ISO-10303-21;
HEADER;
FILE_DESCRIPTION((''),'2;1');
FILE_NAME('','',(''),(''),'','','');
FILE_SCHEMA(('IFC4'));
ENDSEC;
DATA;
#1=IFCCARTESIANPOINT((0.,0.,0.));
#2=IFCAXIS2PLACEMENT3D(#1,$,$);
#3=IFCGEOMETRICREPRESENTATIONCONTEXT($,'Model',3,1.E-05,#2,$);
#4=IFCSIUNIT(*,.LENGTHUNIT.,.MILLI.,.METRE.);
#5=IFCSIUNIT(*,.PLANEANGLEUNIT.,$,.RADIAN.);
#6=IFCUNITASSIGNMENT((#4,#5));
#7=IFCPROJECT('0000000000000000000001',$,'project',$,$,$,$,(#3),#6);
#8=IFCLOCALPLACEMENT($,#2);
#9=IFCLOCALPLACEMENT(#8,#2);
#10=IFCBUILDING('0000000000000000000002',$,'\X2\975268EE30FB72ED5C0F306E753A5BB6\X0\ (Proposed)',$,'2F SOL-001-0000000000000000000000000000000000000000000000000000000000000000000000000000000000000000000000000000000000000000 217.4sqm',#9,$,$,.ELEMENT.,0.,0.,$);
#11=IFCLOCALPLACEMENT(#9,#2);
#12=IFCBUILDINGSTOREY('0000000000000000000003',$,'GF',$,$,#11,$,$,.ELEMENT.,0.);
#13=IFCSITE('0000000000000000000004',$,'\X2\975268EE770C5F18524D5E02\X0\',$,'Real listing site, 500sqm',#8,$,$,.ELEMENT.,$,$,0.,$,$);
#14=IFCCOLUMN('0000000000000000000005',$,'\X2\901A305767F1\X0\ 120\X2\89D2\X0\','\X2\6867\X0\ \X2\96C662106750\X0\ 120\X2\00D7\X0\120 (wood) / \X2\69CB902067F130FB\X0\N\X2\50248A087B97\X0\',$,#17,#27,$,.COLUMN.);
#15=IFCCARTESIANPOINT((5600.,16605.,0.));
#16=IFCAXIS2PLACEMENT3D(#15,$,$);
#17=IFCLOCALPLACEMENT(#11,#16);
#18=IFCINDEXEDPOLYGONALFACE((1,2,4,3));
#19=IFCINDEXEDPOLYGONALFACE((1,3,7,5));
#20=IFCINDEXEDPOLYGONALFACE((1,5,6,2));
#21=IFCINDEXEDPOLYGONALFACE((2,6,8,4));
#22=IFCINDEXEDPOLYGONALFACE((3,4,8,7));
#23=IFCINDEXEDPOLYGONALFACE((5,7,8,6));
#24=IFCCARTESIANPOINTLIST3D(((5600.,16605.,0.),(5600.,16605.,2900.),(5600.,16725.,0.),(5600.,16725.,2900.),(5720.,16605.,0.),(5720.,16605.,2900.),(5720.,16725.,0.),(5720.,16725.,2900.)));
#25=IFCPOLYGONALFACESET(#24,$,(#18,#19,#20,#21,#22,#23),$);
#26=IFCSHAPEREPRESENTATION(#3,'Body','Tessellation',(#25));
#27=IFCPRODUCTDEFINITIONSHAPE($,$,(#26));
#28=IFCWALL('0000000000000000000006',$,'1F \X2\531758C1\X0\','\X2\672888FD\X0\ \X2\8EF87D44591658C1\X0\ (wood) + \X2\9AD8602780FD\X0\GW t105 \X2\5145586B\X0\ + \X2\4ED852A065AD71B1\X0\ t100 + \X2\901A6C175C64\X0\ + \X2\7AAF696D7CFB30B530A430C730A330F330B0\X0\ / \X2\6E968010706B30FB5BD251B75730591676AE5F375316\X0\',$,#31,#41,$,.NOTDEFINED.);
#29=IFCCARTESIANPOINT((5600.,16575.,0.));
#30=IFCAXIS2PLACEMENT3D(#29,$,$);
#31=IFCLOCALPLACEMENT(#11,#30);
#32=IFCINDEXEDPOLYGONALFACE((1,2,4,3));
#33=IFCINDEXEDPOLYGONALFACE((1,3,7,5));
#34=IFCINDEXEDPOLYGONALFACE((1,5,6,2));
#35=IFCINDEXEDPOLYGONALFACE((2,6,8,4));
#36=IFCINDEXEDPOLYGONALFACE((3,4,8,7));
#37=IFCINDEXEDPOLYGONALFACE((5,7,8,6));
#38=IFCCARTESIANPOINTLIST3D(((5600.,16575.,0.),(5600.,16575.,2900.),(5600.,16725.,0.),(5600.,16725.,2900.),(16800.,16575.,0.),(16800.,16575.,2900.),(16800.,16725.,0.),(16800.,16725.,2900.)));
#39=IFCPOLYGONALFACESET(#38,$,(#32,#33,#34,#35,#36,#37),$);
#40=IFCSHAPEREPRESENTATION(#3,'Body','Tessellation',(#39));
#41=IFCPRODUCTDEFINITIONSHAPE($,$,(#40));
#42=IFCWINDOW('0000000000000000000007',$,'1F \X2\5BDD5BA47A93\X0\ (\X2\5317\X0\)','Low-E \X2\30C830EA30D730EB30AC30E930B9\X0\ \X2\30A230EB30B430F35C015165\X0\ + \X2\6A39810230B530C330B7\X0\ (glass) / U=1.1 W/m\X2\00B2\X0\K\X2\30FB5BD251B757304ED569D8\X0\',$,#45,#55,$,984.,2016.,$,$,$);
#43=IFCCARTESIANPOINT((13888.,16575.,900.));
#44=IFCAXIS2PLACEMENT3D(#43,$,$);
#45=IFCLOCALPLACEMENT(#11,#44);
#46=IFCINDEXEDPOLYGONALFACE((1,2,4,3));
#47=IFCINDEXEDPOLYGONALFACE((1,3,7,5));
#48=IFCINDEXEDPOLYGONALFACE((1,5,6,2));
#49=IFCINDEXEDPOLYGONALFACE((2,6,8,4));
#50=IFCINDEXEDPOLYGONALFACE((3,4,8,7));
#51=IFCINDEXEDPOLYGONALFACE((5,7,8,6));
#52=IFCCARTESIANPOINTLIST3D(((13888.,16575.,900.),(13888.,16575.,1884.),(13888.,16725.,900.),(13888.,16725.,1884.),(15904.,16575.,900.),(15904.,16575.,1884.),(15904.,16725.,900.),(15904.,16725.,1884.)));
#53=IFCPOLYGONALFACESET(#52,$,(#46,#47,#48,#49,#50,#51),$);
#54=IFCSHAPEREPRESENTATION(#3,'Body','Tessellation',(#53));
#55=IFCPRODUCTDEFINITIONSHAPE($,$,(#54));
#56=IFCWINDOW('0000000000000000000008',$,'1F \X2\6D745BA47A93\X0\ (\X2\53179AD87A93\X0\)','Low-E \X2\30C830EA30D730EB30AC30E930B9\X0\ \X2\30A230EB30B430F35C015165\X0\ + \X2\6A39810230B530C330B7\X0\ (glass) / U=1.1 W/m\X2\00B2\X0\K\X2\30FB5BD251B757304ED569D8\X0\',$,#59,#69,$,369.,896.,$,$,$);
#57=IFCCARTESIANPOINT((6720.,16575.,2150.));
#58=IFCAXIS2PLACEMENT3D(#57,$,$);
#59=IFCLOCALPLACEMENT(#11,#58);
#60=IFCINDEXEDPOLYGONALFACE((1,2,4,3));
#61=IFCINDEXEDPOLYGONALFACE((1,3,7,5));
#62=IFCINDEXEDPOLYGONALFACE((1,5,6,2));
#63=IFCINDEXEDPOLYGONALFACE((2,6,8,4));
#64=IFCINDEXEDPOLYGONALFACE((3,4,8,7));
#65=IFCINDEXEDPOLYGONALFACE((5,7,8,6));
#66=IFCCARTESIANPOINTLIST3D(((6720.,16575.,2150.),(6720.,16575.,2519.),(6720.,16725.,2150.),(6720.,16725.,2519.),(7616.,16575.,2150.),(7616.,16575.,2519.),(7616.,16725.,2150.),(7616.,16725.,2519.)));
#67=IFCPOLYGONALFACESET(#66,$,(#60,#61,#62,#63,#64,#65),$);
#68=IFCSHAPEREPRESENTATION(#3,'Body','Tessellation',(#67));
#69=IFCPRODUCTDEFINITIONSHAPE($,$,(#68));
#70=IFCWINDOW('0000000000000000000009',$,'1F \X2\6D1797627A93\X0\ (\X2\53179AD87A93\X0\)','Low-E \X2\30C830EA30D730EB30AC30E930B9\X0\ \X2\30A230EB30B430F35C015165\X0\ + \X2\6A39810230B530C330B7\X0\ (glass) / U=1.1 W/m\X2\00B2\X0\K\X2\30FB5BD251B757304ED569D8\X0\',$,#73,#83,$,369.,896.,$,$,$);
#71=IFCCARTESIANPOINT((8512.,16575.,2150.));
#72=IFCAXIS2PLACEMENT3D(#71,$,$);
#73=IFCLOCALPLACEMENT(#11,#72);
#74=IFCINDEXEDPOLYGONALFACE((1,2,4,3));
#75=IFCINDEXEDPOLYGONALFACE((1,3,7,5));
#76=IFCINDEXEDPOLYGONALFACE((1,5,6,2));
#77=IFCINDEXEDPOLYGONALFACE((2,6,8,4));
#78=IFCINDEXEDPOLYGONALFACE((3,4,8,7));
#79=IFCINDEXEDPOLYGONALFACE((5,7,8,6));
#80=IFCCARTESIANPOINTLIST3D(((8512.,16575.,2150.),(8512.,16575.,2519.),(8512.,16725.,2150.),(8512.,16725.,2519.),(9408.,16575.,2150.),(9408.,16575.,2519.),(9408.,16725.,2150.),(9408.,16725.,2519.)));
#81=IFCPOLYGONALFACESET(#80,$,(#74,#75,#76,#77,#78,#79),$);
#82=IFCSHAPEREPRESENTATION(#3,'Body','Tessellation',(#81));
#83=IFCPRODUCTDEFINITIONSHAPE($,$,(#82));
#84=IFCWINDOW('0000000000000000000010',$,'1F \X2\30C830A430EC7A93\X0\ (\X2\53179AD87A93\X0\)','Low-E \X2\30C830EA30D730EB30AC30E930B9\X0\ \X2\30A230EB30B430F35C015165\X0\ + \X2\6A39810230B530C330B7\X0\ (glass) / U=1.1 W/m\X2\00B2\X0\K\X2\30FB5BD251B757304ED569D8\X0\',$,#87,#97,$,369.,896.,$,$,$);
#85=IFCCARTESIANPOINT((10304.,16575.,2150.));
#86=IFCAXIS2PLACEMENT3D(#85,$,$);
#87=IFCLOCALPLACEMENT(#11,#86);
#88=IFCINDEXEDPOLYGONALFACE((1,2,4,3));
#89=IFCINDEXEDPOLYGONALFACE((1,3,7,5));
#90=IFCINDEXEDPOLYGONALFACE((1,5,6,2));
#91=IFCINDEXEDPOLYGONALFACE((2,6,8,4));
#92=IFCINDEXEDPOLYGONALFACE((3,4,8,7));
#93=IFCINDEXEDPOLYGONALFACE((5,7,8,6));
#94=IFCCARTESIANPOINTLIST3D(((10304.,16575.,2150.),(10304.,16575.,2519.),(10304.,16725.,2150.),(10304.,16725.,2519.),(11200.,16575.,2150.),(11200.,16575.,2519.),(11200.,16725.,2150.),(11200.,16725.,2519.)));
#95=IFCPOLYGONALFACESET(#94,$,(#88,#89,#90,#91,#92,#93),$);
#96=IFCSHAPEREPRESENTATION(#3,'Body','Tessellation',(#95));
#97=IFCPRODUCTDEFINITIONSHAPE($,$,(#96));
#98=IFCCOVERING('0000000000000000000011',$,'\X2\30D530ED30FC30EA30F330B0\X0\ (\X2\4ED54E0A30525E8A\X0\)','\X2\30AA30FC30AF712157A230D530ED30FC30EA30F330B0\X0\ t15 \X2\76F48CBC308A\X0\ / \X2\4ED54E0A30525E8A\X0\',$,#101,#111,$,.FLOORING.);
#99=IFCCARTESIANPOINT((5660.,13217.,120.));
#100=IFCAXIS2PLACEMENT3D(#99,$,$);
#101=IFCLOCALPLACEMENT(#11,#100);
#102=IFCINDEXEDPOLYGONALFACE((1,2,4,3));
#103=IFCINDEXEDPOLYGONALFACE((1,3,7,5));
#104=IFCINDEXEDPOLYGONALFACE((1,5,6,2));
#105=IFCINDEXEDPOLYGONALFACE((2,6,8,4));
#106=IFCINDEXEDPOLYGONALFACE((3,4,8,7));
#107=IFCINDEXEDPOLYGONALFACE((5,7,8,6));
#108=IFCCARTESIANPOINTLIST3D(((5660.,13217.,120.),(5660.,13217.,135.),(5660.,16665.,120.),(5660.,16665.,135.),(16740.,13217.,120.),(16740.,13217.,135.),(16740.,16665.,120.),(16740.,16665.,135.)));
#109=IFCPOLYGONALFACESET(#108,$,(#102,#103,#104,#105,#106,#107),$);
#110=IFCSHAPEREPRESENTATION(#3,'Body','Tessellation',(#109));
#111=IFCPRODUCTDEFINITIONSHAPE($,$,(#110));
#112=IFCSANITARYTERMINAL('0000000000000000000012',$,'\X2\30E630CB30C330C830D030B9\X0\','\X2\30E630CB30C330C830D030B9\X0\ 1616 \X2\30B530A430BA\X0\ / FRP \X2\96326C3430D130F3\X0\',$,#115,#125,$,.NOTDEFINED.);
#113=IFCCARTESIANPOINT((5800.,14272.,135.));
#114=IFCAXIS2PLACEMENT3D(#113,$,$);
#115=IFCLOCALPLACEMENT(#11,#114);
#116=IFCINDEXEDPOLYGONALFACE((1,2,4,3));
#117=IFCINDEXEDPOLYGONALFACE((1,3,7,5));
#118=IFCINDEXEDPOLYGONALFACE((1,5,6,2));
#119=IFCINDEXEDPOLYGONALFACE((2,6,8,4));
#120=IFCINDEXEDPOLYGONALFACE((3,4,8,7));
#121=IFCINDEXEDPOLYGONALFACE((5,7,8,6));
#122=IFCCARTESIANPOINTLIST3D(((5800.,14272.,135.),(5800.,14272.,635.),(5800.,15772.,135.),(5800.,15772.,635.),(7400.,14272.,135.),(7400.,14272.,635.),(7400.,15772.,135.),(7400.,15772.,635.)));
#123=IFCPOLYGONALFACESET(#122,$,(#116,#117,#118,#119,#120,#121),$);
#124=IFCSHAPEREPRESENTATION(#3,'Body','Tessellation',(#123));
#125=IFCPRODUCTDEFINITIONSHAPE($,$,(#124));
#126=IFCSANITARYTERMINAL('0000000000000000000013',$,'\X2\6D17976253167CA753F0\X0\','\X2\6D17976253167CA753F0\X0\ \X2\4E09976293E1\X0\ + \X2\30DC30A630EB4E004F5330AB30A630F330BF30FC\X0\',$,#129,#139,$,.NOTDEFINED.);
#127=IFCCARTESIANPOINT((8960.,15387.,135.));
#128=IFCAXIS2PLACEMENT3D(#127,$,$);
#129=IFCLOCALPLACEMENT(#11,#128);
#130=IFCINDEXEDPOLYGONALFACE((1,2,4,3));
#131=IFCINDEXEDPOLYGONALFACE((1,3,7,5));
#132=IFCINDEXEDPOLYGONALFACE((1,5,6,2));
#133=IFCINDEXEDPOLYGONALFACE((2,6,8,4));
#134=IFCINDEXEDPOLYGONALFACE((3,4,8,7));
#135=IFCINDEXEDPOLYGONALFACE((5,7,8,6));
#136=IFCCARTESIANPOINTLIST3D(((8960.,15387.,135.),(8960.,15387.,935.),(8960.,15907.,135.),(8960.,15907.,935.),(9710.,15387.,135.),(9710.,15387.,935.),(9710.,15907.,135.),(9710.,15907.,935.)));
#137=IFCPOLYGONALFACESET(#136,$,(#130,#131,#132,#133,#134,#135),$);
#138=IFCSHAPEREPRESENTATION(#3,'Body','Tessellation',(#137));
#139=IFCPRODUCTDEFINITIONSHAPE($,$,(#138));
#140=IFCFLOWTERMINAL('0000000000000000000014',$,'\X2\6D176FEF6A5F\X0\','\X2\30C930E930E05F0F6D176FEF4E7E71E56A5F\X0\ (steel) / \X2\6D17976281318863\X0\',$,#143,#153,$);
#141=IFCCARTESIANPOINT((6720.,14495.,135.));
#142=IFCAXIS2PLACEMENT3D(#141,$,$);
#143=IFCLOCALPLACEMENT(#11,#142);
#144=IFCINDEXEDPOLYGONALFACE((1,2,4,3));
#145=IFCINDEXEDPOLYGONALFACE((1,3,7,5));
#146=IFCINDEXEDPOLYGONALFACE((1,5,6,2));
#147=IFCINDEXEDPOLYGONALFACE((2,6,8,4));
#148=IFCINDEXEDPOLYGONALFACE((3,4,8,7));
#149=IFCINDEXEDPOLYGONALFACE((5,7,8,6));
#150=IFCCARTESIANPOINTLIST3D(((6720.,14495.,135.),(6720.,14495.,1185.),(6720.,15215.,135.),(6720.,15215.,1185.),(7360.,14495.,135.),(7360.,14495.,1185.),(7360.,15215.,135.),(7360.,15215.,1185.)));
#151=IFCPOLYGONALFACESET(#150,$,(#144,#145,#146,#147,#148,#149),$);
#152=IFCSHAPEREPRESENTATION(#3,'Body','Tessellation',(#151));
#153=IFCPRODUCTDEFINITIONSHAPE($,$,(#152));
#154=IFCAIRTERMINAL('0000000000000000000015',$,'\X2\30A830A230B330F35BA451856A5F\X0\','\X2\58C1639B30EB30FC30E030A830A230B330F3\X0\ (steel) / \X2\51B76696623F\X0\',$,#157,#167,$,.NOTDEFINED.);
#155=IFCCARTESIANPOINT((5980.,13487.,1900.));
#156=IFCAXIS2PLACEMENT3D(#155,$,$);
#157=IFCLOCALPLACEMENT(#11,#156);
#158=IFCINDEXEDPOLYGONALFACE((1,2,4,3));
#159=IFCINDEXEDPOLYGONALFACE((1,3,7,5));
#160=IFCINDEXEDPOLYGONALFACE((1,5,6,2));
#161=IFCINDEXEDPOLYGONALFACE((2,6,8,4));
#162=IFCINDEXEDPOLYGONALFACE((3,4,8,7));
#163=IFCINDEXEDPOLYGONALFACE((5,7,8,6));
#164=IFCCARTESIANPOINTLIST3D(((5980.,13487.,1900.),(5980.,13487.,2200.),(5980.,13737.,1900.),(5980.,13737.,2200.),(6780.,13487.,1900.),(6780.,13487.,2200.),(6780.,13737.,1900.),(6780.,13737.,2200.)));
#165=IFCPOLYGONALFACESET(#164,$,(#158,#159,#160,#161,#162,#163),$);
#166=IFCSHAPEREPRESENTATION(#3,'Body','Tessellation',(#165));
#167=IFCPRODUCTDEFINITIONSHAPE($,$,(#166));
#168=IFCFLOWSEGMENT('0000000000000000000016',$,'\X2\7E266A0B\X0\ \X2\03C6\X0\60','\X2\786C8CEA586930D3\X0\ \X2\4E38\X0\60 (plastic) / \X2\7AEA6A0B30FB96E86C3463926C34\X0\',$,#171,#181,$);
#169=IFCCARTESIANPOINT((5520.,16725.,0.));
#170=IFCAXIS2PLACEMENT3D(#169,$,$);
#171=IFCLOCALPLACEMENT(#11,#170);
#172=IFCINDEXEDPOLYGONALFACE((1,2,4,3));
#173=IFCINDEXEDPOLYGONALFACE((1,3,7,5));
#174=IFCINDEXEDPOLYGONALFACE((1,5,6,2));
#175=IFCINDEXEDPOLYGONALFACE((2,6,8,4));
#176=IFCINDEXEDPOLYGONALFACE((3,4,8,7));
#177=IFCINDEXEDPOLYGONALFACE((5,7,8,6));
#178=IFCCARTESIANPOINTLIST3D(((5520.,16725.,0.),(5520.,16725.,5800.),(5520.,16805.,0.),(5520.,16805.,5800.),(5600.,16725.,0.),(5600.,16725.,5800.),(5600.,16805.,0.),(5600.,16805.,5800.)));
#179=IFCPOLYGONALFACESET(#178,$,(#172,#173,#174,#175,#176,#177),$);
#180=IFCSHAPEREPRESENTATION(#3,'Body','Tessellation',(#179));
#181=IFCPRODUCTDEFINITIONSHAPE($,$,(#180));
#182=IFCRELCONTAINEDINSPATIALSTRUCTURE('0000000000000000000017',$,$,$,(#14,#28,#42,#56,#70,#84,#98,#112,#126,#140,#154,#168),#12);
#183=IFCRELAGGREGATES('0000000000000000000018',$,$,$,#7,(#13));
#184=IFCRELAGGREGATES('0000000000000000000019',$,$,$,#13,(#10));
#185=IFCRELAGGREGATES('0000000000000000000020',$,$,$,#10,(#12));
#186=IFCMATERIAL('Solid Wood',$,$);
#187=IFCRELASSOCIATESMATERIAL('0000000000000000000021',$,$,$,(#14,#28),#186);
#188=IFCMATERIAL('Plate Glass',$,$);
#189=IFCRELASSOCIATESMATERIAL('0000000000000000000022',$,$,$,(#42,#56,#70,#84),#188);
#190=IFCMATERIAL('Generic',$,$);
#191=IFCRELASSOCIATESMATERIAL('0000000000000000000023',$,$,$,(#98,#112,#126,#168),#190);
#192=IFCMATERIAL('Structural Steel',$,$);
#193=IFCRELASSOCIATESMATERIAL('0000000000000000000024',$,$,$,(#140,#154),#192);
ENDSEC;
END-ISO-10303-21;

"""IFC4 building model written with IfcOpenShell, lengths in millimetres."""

from ifc_helpers import new_model, si_unit, frame, frame_2d, origin, place, context, project, spatial, rectangle, extrude, material, element, fill, save


model = new_model("IFC4")

# Units and contexts
model_context = context("Model", 3, precision=1e-05, world=origin())
ifc_project = project(units=[si_unit("LENGTHUNIT", "METRE", prefix="MILLI"), si_unit("PLANEANGLEUNIT", "RADIAN")], contexts=[model_context])

# Site, building, storey
site_placement = place(None, origin())
site = spatial("IfcSite", under=ifc_project, at=site_placement, Name="青森県弘前市", ObjectType="Real listing site, 500sqm", CompositionType="ELEMENT", RefElevation=0.0)
building_placement = place(site_placement, origin())
building = spatial("IfcBuilding", under=site, at=building_placement, Name="青森・狭小の町家 (Proposed)", ObjectType="2F SOL-001-0000000000000000000000000000000000000000000000000000000000000000000000000000000000000000000000000000000000000000 217.4sqm", CompositionType="ELEMENT", ElevationOfRefHeight=0.0, ElevationOfTerrain=0.0)
storey_placement = place(building_placement, origin())
storey = spatial("IfcBuildingStorey", under=building, at=storey_placement, Name="GF", CompositionType="ELEMENT", Elevation=0.0)

# Column
ifc_material_1 = material(Name="Solid Wood")
column_1_placement = place(storey_placement, frame((5600.0, 16605.0, 0.0)))
element("IfcColumn", 1, at=column_1_placement, inside=storey, material=ifc_material_1, Name="通し柱 120角", Description="桧 集成材 120×120 (wood) / 構造柱・N値計算", PredefinedType="COLUMN", context=model_context, shape_type="SweptSolid", body=[
    extrude(rectangle(XDim=120.0, YDim=120.0, at=frame_2d((60.0, 60.0))), frame((5600.0, 16605.0, 0.0)), (0.0, 0.0, 1.0), 2900.0),
])

# Wall, openings, windows
wall_1_placement = place(storey_placement, frame((5600.0, 16575.0, 0.0)))
wall_1 = element("IfcWall", 2, at=wall_1_placement, inside=storey, material=ifc_material_1, Name="1F 北壁", Description="木製 軸組外壁 (wood) + 高性能GW t105 充填 + 付加断熱 t100 + 通気層 + 窯業系サイディング / 準耐火・寒冷地外皮強化", PredefinedType="NOTDEFINED", context=model_context, shape_type="SweptSolid", body=[
    extrude(rectangle(XDim=11200.0, YDim=150.0, at=frame_2d((5600.0, 75.0))), frame((5600.0, 16575.0, 0.0)), (0.0, 0.0, 1.0), 2900.0),
])
opening_1_placement = place(storey_placement, frame((13888.0, 16575.0, 900.0)))
opening_1 = element("IfcOpeningElement", 3, at=opening_1_placement, cuts=wall_1, PredefinedType="NOTDEFINED", context=model_context, shape_type="SweptSolid", body=[
    extrude(rectangle(XDim=2016.0, YDim=150.0, at=frame_2d((1008.0, 75.0))), frame((13888.0, 16575.0, 900.0)), (0.0, 0.0, 1.0), 984.0),
])
opening_2_placement = place(storey_placement, frame((6720.0, 16575.0, 2150.0)))
opening_2 = element("IfcOpeningElement", 4, at=opening_2_placement, cuts=wall_1, PredefinedType="NOTDEFINED", context=model_context, shape_type="SweptSolid", body=[
    extrude(rectangle(XDim=896.0, YDim=150.0, at=frame_2d((448.0, 75.0))), frame((6720.0, 16575.0, 2150.0)), (0.0, 0.0, 1.0), 369.0),
])
opening_3_placement = place(storey_placement, frame((8512.0, 16575.0, 2150.0)))
opening_3 = element("IfcOpeningElement", 5, at=opening_3_placement, cuts=wall_1, PredefinedType="NOTDEFINED", context=model_context, shape_type="SweptSolid", body=[
    extrude(rectangle(XDim=896.0, YDim=150.0, at=frame_2d((448.0, 75.0))), frame((8512.0, 16575.0, 2150.0)), (0.0, 0.0, 1.0), 369.0),
])
opening_4_placement = place(storey_placement, frame((10304.0, 16575.0, 2150.0)))
opening_4 = element("IfcOpeningElement", 6, at=opening_4_placement, cuts=wall_1, PredefinedType="NOTDEFINED", context=model_context, shape_type="SweptSolid", body=[
    extrude(rectangle(XDim=896.0, YDim=150.0, at=frame_2d((448.0, 75.0))), frame((10304.0, 16575.0, 2150.0)), (0.0, 0.0, 1.0), 369.0),
])
ifc_material_2 = material(Name="Plate Glass")
window_1_placement = place(storey_placement, frame((13888.0, 16575.0, 900.0)))
window_1 = element("IfcWindow", 7, at=window_1_placement, inside=storey, material=ifc_material_2, Name="1F 寝室窓 (北)", Description="Low-E トリプルガラス アルゴン封入 + 樹脂サッシ (glass) / U=1.1 W/m²K・寒冷地仕様", OverallHeight=984.0, OverallWidth=2016.0, context=model_context, shape_type="SweptSolid", body=[
    extrude(rectangle(XDim=2016.0, YDim=150.0, at=frame_2d((1008.0, 75.0))), frame((13888.0, 16575.0, 900.0)), (0.0, 0.0, 1.0), 984.0),
])
fill(opening_1, window_1)
window_2_placement = place(storey_placement, frame((6720.0, 16575.0, 2150.0)))
window_2 = element("IfcWindow", 8, at=window_2_placement, inside=storey, material=ifc_material_2, Name="1F 浴室窓 (北高窓)", Description="Low-E トリプルガラス アルゴン封入 + 樹脂サッシ (glass) / U=1.1 W/m²K・寒冷地仕様", OverallHeight=369.0, OverallWidth=896.0, context=model_context, shape_type="SweptSolid", body=[
    extrude(rectangle(XDim=896.0, YDim=150.0, at=frame_2d((448.0, 75.0))), frame((6720.0, 16575.0, 2150.0)), (0.0, 0.0, 1.0), 369.0),
])
fill(opening_2, window_2)
window_3_placement = place(storey_placement, frame((8512.0, 16575.0, 2150.0)))
window_3 = element("IfcWindow", 9, at=window_3_placement, inside=storey, material=ifc_material_2, Name="1F 洗面窓 (北高窓)", Description="Low-E トリプルガラス アルゴン封入 + 樹脂サッシ (glass) / U=1.1 W/m²K・寒冷地仕様", OverallHeight=369.0, OverallWidth=896.0, context=model_context, shape_type="SweptSolid", body=[
    extrude(rectangle(XDim=896.0, YDim=150.0, at=frame_2d((448.0, 75.0))), frame((8512.0, 16575.0, 2150.0)), (0.0, 0.0, 1.0), 369.0),
])
fill(opening_3, window_3)
window_4_placement = place(storey_placement, frame((10304.0, 16575.0, 2150.0)))
window_4 = element("IfcWindow", 10, at=window_4_placement, inside=storey, material=ifc_material_2, Name="1F トイレ窓 (北高窓)", Description="Low-E トリプルガラス アルゴン封入 + 樹脂サッシ (glass) / U=1.1 W/m²K・寒冷地仕様", OverallHeight=369.0, OverallWidth=896.0, context=model_context, shape_type="SweptSolid", body=[
    extrude(rectangle(XDim=896.0, YDim=150.0, at=frame_2d((448.0, 75.0))), frame((10304.0, 16575.0, 2150.0)), (0.0, 0.0, 1.0), 369.0),
])
fill(opening_4, window_4)

# Covering
ifc_material_3 = material(Name="Generic")
covering_placement = place(storey_placement, frame((5660.0, 13217.0, 120.0)))
element("IfcCovering", 11, at=covering_placement, inside=storey, material=ifc_material_3, Name="フローリング (仕上げ床)", Description="オーク無垢フローリング t15 直貼り / 仕上げ床", PredefinedType="FLOORING", context=model_context, shape_type="SweptSolid", body=[
    extrude(rectangle(XDim=11080.0, YDim=3448.0, at=frame_2d((5540.0, 1724.0))), frame((5660.0, 13217.0, 120.0)), (0.0, 0.0, 1.0), 15.0),
])

# Sanitary terminals
sanitary_terminal_1_placement = place(storey_placement, frame((5800.0, 14272.0, 135.0)))
element("IfcSanitaryTerminal", 12, at=sanitary_terminal_1_placement, inside=storey, material=ifc_material_3, Name="ユニットバス", Description="ユニットバス 1616 サイズ / FRP 防水パン", PredefinedType="NOTDEFINED", context=model_context, shape_type="SweptSolid", body=[
    extrude(rectangle(XDim=1600.0, YDim=1500.0, at=frame_2d((800.0, 750.0))), frame((5800.0, 14272.0, 135.0)), (0.0, 0.0, 1.0), 500.0),
])
sanitary_terminal_2_placement = place(storey_placement, frame((8960.0, 15387.0, 135.0)))
element("IfcSanitaryTerminal", 13, at=sanitary_terminal_2_placement, inside=storey, material=ifc_material_3, Name="洗面化粧台", Description="洗面化粧台 三面鏡 + ボウル一体カウンター", PredefinedType="NOTDEFINED", context=model_context, shape_type="SweptSolid", body=[
    extrude(rectangle(XDim=750.0, YDim=520.0, at=frame_2d((375.0, 260.0))), frame((8960.0, 15387.0, 135.0)), (0.0, 0.0, 1.0), 800.0),
])

# Flow terminal
ifc_material_4 = material(Name="Structural Steel")
flow_terminal_placement = place(storey_placement, frame((6720.0, 14495.0, 135.0)))
element("IfcFlowTerminal", 14, at=flow_terminal_placement, inside=storey, material=ifc_material_4, Name="洗濯機", Description="ドラム式洗濯乾燥機 (steel) / 洗面脱衣", context=model_context, shape_type="SweptSolid", body=[
    extrude(rectangle(XDim=640.0, YDim=720.0, at=frame_2d((320.0, 360.0))), frame((6720.0, 14495.0, 135.0)), (0.0, 0.0, 1.0), 1050.0),
])

# Air terminal
air_terminal_placement = place(storey_placement, frame((5980.0, 13487.0, 1900.0)))
element("IfcAirTerminal", 15, at=air_terminal_placement, inside=storey, material=ifc_material_4, Name="エアコン室内機", Description="壁掛ルームエアコン (steel) / 冷暖房", PredefinedType="NOTDEFINED", context=model_context, shape_type="SweptSolid", body=[
    extrude(rectangle(XDim=800.0, YDim=250.0, at=frame_2d((400.0, 125.0))), frame((5980.0, 13487.0, 1900.0)), (0.0, 0.0, 1.0), 300.0),
])

# Flow segment
flow_segment_placement = place(storey_placement, frame((5520.0, 16725.0, 0.0)))
element("IfcFlowSegment", 16, at=flow_segment_placement, inside=storey, material=ifc_material_3, Name="縦樋 φ60", Description="硬質塩ビ 丸60 (plastic) / 竪樋・雨水排水", context=model_context, shape_type="SweptSolid", body=[
    extrude(rectangle(XDim=80.0, YDim=80.0, at=frame_2d((40.0, 40.0))), frame((5520.0, 16725.0, 0.0)), (0.0, 0.0, 1.0), 5800.0),
])

save(model, "model.ifc")
